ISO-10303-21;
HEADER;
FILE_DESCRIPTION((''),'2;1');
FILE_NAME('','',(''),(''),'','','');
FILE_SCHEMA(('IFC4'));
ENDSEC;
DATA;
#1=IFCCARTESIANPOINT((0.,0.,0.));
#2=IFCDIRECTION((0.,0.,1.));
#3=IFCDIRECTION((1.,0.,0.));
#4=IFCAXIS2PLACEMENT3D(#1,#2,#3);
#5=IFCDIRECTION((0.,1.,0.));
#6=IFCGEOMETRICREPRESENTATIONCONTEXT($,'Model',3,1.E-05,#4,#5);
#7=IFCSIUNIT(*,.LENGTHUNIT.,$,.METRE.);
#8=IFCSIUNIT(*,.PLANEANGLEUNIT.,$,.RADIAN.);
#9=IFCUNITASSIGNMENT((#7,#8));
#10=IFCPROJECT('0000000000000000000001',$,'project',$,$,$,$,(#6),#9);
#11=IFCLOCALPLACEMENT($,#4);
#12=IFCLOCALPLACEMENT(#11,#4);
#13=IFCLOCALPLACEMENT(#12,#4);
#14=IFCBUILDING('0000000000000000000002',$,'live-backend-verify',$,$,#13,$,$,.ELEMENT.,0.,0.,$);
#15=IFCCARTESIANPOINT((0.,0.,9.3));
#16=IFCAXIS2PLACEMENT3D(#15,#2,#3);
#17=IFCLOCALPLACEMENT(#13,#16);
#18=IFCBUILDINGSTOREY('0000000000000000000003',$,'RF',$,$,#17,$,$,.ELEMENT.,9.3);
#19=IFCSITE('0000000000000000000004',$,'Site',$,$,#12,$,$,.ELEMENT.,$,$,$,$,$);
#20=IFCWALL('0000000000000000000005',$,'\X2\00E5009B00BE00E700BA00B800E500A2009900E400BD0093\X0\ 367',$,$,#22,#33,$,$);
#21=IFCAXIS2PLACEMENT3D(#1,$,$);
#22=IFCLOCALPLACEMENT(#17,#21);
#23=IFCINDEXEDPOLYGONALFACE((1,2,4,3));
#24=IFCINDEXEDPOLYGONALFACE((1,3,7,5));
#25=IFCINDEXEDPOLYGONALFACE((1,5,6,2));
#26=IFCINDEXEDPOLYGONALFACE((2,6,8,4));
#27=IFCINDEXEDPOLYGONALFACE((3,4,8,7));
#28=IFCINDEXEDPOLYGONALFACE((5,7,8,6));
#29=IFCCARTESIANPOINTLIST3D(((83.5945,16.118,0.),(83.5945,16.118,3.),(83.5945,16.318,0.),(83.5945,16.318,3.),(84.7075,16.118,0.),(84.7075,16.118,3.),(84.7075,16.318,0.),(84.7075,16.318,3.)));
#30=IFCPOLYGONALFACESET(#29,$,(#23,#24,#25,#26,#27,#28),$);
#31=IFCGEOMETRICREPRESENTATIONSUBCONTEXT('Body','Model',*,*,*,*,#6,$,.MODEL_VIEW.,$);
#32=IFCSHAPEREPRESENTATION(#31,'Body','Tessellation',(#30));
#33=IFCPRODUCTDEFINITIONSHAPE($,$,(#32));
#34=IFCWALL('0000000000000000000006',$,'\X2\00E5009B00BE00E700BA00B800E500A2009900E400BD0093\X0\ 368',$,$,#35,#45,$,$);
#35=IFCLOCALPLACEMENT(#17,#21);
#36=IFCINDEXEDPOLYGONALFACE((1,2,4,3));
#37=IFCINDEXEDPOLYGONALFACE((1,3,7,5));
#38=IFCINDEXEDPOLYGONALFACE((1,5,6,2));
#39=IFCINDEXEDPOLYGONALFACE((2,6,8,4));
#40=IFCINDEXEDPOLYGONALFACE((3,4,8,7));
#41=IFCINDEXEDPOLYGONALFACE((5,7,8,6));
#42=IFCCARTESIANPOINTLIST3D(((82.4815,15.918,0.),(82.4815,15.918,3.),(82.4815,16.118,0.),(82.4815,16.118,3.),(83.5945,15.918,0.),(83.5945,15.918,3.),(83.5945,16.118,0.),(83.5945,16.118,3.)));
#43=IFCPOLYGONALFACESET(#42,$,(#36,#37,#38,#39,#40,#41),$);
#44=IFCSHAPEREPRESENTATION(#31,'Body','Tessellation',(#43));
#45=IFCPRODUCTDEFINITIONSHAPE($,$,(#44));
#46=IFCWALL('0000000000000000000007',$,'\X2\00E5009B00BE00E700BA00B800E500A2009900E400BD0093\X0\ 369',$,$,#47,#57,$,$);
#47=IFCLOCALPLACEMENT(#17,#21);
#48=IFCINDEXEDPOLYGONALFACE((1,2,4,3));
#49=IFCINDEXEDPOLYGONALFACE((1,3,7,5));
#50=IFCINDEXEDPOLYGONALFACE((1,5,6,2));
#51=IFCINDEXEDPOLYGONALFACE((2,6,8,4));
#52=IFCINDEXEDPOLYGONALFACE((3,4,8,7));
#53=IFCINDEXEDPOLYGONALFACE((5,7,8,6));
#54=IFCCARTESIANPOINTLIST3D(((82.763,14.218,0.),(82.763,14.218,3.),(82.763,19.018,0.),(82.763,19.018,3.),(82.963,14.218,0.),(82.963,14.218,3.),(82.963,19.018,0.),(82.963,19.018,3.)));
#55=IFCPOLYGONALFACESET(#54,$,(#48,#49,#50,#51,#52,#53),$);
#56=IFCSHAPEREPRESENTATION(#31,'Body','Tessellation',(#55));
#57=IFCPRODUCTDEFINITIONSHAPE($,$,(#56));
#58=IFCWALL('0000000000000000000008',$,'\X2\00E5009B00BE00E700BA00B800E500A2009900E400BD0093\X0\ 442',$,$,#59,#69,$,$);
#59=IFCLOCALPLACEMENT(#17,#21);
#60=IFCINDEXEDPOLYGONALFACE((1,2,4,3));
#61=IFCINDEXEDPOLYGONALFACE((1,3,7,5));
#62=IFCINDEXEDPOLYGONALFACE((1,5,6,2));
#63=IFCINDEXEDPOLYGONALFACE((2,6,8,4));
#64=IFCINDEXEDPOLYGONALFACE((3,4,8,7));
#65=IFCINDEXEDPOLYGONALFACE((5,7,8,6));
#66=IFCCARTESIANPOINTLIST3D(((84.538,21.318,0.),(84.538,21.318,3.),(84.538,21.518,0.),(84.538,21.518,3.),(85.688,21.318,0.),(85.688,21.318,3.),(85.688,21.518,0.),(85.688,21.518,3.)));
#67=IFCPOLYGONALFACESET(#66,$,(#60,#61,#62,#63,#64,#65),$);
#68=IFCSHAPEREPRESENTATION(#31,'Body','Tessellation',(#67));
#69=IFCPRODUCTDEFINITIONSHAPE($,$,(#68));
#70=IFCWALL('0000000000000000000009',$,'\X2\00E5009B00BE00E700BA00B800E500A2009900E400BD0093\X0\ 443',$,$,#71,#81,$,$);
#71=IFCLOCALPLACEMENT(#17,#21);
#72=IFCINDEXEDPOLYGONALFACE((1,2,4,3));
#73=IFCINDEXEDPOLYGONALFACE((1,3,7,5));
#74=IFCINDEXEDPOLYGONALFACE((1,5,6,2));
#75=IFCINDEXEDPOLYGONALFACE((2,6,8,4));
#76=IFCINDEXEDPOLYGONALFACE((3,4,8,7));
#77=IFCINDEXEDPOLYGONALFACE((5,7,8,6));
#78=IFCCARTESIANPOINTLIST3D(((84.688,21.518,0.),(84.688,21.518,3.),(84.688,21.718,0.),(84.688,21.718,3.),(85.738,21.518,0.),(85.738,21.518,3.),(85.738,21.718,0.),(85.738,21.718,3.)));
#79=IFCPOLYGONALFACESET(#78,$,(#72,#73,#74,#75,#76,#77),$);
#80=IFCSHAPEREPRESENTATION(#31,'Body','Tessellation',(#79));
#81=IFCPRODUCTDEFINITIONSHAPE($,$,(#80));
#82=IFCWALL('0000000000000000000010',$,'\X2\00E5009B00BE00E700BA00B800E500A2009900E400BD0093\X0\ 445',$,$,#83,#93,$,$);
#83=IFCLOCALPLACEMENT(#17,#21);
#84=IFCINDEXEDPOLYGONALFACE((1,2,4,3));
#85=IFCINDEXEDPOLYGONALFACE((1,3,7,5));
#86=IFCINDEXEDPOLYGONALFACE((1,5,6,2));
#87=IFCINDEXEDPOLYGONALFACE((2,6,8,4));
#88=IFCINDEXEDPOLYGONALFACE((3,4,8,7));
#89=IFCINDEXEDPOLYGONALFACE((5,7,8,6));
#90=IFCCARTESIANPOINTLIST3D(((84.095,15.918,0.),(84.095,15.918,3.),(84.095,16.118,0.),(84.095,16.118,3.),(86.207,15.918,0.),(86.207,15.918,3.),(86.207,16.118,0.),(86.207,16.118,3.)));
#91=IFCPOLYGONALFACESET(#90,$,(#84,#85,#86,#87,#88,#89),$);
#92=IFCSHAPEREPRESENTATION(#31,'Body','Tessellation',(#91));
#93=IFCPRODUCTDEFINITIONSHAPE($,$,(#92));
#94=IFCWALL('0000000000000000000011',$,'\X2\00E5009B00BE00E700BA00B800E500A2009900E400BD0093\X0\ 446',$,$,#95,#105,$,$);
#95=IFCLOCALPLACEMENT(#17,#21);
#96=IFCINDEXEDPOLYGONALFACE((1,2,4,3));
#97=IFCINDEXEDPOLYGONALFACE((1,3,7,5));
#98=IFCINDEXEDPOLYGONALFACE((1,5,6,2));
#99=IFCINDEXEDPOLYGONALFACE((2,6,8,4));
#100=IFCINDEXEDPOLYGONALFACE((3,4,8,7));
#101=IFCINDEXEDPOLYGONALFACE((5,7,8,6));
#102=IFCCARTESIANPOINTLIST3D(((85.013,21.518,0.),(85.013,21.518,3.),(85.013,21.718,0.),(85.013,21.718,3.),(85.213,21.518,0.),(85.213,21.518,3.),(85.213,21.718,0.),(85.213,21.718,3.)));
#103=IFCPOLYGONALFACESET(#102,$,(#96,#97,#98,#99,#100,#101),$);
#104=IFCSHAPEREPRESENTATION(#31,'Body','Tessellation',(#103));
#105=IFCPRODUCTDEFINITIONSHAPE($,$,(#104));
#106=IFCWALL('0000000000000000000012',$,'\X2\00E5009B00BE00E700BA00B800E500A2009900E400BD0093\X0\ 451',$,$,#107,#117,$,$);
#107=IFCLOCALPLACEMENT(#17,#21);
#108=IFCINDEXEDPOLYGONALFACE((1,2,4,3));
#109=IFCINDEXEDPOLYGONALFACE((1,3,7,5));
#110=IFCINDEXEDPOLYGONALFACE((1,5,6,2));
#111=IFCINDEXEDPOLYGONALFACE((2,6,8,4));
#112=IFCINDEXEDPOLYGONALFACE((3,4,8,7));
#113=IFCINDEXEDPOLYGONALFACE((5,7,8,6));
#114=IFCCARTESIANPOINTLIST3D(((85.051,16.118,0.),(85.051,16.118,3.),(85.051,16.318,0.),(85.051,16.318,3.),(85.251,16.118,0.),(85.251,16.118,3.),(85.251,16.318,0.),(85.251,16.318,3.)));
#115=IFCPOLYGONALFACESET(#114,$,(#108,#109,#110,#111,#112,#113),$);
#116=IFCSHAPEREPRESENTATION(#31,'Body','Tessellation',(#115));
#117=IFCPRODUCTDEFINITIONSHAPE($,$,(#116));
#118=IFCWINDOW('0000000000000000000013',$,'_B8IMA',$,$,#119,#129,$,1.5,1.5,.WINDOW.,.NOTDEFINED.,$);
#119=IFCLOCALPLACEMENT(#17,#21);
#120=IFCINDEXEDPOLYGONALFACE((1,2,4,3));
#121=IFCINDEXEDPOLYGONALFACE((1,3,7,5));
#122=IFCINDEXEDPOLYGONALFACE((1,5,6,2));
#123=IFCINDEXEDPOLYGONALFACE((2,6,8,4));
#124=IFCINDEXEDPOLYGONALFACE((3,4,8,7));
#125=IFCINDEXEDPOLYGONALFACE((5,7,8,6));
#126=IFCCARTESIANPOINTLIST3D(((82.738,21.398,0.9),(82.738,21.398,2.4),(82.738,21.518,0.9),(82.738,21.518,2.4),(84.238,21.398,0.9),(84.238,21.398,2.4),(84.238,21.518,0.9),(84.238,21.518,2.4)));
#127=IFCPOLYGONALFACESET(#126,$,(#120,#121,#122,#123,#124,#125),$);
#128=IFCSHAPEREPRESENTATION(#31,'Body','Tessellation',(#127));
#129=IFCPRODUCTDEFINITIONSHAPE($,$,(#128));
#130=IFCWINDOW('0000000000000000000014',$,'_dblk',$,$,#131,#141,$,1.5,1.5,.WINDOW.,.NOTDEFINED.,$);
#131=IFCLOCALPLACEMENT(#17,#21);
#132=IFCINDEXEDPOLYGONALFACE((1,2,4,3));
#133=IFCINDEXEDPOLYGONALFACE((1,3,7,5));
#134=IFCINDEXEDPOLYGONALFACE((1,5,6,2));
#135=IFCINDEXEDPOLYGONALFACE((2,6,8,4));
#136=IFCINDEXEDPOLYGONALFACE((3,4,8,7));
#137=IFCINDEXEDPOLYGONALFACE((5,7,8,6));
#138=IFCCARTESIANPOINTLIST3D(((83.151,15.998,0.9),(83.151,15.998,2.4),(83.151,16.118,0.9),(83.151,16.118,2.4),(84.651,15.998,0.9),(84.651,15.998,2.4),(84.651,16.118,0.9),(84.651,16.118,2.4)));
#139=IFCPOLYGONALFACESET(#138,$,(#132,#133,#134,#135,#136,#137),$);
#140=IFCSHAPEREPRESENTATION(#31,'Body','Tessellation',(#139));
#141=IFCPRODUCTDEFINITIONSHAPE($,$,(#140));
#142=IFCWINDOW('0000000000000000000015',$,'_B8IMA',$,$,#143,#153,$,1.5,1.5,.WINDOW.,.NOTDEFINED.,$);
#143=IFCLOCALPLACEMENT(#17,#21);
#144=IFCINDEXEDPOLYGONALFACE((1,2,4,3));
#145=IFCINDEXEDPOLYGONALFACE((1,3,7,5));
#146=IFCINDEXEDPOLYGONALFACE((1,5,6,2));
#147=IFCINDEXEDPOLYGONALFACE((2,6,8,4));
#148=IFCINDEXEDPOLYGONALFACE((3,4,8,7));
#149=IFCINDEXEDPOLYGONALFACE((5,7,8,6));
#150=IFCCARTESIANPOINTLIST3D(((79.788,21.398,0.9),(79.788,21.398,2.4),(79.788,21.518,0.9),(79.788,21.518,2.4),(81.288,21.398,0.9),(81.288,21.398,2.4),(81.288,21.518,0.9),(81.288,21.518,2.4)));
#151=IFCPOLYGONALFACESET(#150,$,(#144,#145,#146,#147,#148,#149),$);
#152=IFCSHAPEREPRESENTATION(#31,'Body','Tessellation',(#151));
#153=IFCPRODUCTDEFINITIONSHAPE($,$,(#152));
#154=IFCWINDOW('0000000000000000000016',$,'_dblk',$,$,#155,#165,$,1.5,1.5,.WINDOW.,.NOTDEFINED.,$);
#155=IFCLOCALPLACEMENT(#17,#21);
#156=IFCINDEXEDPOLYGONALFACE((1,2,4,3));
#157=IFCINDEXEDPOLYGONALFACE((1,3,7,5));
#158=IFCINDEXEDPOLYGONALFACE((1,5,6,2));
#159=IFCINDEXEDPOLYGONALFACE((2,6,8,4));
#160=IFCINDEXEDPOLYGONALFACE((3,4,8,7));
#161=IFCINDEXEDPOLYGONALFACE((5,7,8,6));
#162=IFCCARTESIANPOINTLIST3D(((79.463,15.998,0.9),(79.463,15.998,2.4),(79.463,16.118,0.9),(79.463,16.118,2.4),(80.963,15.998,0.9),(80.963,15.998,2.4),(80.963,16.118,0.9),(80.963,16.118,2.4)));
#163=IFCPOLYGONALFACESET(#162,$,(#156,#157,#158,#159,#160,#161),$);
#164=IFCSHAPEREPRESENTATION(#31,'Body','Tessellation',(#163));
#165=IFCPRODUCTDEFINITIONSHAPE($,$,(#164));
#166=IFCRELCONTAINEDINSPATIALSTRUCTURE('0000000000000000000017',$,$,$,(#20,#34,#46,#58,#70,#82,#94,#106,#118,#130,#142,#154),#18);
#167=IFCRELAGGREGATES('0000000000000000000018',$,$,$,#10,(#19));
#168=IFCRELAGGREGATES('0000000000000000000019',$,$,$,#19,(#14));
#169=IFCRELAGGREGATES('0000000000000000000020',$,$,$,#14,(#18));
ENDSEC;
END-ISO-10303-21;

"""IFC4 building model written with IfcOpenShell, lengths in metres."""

from ifc_helpers import new_model, si_unit, direction, frame, frame_2d, origin_with_axes, place, context, subcontext, project, spatial, rectangle, extrude, element, save


model = new_model("IFC4")

# Units and contexts
model_context = context("Model", 3, precision=1e-05, world=origin_with_axes(), true_north=direction((0.0, 1.0, 0.0)))
body_context = subcontext(model_context, "Body", "Model", "MODEL_VIEW")
ifc_project = project(units=[si_unit("LENGTHUNIT", "METRE"), si_unit("PLANEANGLEUNIT", "RADIAN")], contexts=[model_context])

# Site, building, storey
placement = place(None, origin_with_axes())
site_placement = place(placement, origin_with_axes())
site = spatial("IfcSite", under=ifc_project, at=site_placement, Name="Site", CompositionType="ELEMENT")
building_placement = place(site_placement, origin_with_axes())
building = spatial("IfcBuilding", under=site, at=building_placement, Name="live-backend-verify", CompositionType="ELEMENT", ElevationOfRefHeight=0.0, ElevationOfTerrain=0.0)
storey_placement = place(building_placement, frame((0.0, 0.0, 9.3), z_axis=(0.0, 0.0, 1.0), x_axis=(1.0, 0.0, 0.0)))
storey = spatial("IfcBuildingStorey", under=building, at=storey_placement, Name="RF", CompositionType="ELEMENT", Elevation=9.3)

# Walls
for number, where, z_axis, x_axis, name in (
    (1, (84.151, 16.218, 0.0), (0.0, 0.0, 1.0), (-1.0, 0.0, 0.0), "å\u009b¾çº¸å¢\u0099ä½\u0093 367"),
    (2, (83.038, 16.018, 0.0), (0.0, 0.0, 1.0), (1.0, 0.0, 0.0), "å\u009b¾çº¸å¢\u0099ä½\u0093 368"),
):
    element("IfcWall", number, at=place(storey_placement, frame(where, z_axis=z_axis, x_axis=x_axis)), inside=storey, Name=name, context=body_context, shape_type="SweptSolid", body=[
        extrude(rectangle(XDim=1.113, YDim=0.2, at=frame_2d((0.0, 0.0), x_axis=(1.0, 0.0, 0.0))), frame((0.0, 0.0, 0.0), z_axis=(0.0, 0.0, 1.0)), (0.0, 0.0, 1.0), 3.0),
    ])
wall_1_placement = place(storey_placement, frame((82.863, 16.618, 0.0), z_axis=(0.0, 0.0, 1.0), x_axis=(0.0, 1.0, 0.0)))
element("IfcWall", 3, at=wall_1_placement, inside=storey, Name="å\u009b¾çº¸å¢\u0099ä½\u0093 369", context=body_context, shape_type="SweptSolid", body=[
    extrude(rectangle(XDim=4.8, YDim=0.2, at=frame_2d((0.0, 0.0), x_axis=(1.0, 0.0, 0.0))), frame((0.0, 0.0, 0.0), z_axis=(0.0, 0.0, 1.0)), (0.0, 0.0, 1.0), 3.0),
])
wall_2_placement = place(storey_placement, frame((85.113, 21.418, 0.0), z_axis=(0.0, 0.0, 1.0), x_axis=(1.0, 0.0, 0.0)))
element("IfcWall", 4, at=wall_2_placement, inside=storey, Name="å\u009b¾çº¸å¢\u0099ä½\u0093 442", context=body_context, shape_type="SweptSolid", body=[
    extrude(rectangle(XDim=1.15, YDim=0.2, at=frame_2d((0.0, 0.0), x_axis=(1.0, 0.0, 0.0))), frame((0.0, 0.0, 0.0), z_axis=(0.0, 0.0, 1.0)), (0.0, 0.0, 1.0), 3.0),
])
wall_3_placement = place(storey_placement, frame((85.213, 21.618, 0.0), z_axis=(0.0, 0.0, 1.0), x_axis=(1.0, 0.0, 0.0)))
element("IfcWall", 5, at=wall_3_placement, inside=storey, Name="å\u009b¾çº¸å¢\u0099ä½\u0093 443", context=body_context, shape_type="SweptSolid", body=[
    extrude(rectangle(XDim=1.05, YDim=0.2, at=frame_2d((0.0, 0.0), x_axis=(1.0, 0.0, 0.0))), frame((0.0, 0.0, 0.0), z_axis=(0.0, 0.0, 1.0)), (0.0, 0.0, 1.0), 3.0),
])
wall_4_placement = place(storey_placement, frame((85.151, 16.018, 0.0), z_axis=(0.0, 0.0, 1.0), x_axis=(1.0, 0.0, 0.0)))
element("IfcWall", 6, at=wall_4_placement, inside=storey, Name="å\u009b¾çº¸å¢\u0099ä½\u0093 445", context=body_context, shape_type="SweptSolid", body=[
    extrude(rectangle(XDim=2.112, YDim=0.2, at=frame_2d((0.0, 0.0), x_axis=(1.0, 0.0, 0.0))), frame((0.0, 0.0, 0.0), z_axis=(0.0, 0.0, 1.0)), (0.0, 0.0, 1.0), 3.0),
])
for number, where, z_axis, x_axis, name in (
    (7, (85.113, 21.618, 0.0), (0.0, 0.0, 1.0), (0.0, -1.0, 0.0), "å\u009b¾çº¸å¢\u0099ä½\u0093 446"),
    (8, (85.151, 16.218, 0.0), (0.0, 0.0, 1.0), (0.0, -1.0, 0.0), "å\u009b¾çº¸å¢\u0099ä½\u0093 451"),
):
    element("IfcWall", number, at=place(storey_placement, frame(where, z_axis=z_axis, x_axis=x_axis)), inside=storey, Name=name, context=body_context, shape_type="SweptSolid", body=[
        extrude(rectangle(XDim=0.2, YDim=0.2, at=frame_2d((0.0, 0.0), x_axis=(1.0, 0.0, 0.0))), frame((0.0, 0.0, 0.0), z_axis=(0.0, 0.0, 1.0)), (0.0, 0.0, 1.0), 3.0),
    ])

# Windows
for number, where, z_axis, x_axis, name in (
    (9, (83.488, 21.458, 0.9), (0.0, 0.0, 1.0), (1.0, 0.0, 0.0), "_B8IMA"),
    (10, (83.901, 16.058, 0.9), (0.0, 0.0, 1.0), (1.0, 0.0, 0.0), "_dblk"),
    (11, (80.538, 21.458, 0.9), (0.0, 0.0, 1.0), (1.0, 0.0, 0.0), "_B8IMA"),
    (12, (80.213, 16.058, 0.9), (0.0, 0.0, 1.0), (1.0, 0.0, 0.0), "_dblk"),
):
    element("IfcWindow", number, at=place(storey_placement, frame(where, z_axis=z_axis, x_axis=x_axis)), inside=storey, Name=name, OverallHeight=1.5, OverallWidth=1.5, PartitioningType="NOTDEFINED", PredefinedType="WINDOW", context=body_context, shape_type="SweptSolid", body=[
        extrude(rectangle(XDim=1.5, YDim=0.12, at=frame_2d((0.0, 0.0), x_axis=(1.0, 0.0, 0.0))), frame((0.0, 0.0, 0.0), z_axis=(0.0, 0.0, 1.0)), (0.0, 0.0, 1.0), 1.5),
    ])

save(model, "model.ifc")
